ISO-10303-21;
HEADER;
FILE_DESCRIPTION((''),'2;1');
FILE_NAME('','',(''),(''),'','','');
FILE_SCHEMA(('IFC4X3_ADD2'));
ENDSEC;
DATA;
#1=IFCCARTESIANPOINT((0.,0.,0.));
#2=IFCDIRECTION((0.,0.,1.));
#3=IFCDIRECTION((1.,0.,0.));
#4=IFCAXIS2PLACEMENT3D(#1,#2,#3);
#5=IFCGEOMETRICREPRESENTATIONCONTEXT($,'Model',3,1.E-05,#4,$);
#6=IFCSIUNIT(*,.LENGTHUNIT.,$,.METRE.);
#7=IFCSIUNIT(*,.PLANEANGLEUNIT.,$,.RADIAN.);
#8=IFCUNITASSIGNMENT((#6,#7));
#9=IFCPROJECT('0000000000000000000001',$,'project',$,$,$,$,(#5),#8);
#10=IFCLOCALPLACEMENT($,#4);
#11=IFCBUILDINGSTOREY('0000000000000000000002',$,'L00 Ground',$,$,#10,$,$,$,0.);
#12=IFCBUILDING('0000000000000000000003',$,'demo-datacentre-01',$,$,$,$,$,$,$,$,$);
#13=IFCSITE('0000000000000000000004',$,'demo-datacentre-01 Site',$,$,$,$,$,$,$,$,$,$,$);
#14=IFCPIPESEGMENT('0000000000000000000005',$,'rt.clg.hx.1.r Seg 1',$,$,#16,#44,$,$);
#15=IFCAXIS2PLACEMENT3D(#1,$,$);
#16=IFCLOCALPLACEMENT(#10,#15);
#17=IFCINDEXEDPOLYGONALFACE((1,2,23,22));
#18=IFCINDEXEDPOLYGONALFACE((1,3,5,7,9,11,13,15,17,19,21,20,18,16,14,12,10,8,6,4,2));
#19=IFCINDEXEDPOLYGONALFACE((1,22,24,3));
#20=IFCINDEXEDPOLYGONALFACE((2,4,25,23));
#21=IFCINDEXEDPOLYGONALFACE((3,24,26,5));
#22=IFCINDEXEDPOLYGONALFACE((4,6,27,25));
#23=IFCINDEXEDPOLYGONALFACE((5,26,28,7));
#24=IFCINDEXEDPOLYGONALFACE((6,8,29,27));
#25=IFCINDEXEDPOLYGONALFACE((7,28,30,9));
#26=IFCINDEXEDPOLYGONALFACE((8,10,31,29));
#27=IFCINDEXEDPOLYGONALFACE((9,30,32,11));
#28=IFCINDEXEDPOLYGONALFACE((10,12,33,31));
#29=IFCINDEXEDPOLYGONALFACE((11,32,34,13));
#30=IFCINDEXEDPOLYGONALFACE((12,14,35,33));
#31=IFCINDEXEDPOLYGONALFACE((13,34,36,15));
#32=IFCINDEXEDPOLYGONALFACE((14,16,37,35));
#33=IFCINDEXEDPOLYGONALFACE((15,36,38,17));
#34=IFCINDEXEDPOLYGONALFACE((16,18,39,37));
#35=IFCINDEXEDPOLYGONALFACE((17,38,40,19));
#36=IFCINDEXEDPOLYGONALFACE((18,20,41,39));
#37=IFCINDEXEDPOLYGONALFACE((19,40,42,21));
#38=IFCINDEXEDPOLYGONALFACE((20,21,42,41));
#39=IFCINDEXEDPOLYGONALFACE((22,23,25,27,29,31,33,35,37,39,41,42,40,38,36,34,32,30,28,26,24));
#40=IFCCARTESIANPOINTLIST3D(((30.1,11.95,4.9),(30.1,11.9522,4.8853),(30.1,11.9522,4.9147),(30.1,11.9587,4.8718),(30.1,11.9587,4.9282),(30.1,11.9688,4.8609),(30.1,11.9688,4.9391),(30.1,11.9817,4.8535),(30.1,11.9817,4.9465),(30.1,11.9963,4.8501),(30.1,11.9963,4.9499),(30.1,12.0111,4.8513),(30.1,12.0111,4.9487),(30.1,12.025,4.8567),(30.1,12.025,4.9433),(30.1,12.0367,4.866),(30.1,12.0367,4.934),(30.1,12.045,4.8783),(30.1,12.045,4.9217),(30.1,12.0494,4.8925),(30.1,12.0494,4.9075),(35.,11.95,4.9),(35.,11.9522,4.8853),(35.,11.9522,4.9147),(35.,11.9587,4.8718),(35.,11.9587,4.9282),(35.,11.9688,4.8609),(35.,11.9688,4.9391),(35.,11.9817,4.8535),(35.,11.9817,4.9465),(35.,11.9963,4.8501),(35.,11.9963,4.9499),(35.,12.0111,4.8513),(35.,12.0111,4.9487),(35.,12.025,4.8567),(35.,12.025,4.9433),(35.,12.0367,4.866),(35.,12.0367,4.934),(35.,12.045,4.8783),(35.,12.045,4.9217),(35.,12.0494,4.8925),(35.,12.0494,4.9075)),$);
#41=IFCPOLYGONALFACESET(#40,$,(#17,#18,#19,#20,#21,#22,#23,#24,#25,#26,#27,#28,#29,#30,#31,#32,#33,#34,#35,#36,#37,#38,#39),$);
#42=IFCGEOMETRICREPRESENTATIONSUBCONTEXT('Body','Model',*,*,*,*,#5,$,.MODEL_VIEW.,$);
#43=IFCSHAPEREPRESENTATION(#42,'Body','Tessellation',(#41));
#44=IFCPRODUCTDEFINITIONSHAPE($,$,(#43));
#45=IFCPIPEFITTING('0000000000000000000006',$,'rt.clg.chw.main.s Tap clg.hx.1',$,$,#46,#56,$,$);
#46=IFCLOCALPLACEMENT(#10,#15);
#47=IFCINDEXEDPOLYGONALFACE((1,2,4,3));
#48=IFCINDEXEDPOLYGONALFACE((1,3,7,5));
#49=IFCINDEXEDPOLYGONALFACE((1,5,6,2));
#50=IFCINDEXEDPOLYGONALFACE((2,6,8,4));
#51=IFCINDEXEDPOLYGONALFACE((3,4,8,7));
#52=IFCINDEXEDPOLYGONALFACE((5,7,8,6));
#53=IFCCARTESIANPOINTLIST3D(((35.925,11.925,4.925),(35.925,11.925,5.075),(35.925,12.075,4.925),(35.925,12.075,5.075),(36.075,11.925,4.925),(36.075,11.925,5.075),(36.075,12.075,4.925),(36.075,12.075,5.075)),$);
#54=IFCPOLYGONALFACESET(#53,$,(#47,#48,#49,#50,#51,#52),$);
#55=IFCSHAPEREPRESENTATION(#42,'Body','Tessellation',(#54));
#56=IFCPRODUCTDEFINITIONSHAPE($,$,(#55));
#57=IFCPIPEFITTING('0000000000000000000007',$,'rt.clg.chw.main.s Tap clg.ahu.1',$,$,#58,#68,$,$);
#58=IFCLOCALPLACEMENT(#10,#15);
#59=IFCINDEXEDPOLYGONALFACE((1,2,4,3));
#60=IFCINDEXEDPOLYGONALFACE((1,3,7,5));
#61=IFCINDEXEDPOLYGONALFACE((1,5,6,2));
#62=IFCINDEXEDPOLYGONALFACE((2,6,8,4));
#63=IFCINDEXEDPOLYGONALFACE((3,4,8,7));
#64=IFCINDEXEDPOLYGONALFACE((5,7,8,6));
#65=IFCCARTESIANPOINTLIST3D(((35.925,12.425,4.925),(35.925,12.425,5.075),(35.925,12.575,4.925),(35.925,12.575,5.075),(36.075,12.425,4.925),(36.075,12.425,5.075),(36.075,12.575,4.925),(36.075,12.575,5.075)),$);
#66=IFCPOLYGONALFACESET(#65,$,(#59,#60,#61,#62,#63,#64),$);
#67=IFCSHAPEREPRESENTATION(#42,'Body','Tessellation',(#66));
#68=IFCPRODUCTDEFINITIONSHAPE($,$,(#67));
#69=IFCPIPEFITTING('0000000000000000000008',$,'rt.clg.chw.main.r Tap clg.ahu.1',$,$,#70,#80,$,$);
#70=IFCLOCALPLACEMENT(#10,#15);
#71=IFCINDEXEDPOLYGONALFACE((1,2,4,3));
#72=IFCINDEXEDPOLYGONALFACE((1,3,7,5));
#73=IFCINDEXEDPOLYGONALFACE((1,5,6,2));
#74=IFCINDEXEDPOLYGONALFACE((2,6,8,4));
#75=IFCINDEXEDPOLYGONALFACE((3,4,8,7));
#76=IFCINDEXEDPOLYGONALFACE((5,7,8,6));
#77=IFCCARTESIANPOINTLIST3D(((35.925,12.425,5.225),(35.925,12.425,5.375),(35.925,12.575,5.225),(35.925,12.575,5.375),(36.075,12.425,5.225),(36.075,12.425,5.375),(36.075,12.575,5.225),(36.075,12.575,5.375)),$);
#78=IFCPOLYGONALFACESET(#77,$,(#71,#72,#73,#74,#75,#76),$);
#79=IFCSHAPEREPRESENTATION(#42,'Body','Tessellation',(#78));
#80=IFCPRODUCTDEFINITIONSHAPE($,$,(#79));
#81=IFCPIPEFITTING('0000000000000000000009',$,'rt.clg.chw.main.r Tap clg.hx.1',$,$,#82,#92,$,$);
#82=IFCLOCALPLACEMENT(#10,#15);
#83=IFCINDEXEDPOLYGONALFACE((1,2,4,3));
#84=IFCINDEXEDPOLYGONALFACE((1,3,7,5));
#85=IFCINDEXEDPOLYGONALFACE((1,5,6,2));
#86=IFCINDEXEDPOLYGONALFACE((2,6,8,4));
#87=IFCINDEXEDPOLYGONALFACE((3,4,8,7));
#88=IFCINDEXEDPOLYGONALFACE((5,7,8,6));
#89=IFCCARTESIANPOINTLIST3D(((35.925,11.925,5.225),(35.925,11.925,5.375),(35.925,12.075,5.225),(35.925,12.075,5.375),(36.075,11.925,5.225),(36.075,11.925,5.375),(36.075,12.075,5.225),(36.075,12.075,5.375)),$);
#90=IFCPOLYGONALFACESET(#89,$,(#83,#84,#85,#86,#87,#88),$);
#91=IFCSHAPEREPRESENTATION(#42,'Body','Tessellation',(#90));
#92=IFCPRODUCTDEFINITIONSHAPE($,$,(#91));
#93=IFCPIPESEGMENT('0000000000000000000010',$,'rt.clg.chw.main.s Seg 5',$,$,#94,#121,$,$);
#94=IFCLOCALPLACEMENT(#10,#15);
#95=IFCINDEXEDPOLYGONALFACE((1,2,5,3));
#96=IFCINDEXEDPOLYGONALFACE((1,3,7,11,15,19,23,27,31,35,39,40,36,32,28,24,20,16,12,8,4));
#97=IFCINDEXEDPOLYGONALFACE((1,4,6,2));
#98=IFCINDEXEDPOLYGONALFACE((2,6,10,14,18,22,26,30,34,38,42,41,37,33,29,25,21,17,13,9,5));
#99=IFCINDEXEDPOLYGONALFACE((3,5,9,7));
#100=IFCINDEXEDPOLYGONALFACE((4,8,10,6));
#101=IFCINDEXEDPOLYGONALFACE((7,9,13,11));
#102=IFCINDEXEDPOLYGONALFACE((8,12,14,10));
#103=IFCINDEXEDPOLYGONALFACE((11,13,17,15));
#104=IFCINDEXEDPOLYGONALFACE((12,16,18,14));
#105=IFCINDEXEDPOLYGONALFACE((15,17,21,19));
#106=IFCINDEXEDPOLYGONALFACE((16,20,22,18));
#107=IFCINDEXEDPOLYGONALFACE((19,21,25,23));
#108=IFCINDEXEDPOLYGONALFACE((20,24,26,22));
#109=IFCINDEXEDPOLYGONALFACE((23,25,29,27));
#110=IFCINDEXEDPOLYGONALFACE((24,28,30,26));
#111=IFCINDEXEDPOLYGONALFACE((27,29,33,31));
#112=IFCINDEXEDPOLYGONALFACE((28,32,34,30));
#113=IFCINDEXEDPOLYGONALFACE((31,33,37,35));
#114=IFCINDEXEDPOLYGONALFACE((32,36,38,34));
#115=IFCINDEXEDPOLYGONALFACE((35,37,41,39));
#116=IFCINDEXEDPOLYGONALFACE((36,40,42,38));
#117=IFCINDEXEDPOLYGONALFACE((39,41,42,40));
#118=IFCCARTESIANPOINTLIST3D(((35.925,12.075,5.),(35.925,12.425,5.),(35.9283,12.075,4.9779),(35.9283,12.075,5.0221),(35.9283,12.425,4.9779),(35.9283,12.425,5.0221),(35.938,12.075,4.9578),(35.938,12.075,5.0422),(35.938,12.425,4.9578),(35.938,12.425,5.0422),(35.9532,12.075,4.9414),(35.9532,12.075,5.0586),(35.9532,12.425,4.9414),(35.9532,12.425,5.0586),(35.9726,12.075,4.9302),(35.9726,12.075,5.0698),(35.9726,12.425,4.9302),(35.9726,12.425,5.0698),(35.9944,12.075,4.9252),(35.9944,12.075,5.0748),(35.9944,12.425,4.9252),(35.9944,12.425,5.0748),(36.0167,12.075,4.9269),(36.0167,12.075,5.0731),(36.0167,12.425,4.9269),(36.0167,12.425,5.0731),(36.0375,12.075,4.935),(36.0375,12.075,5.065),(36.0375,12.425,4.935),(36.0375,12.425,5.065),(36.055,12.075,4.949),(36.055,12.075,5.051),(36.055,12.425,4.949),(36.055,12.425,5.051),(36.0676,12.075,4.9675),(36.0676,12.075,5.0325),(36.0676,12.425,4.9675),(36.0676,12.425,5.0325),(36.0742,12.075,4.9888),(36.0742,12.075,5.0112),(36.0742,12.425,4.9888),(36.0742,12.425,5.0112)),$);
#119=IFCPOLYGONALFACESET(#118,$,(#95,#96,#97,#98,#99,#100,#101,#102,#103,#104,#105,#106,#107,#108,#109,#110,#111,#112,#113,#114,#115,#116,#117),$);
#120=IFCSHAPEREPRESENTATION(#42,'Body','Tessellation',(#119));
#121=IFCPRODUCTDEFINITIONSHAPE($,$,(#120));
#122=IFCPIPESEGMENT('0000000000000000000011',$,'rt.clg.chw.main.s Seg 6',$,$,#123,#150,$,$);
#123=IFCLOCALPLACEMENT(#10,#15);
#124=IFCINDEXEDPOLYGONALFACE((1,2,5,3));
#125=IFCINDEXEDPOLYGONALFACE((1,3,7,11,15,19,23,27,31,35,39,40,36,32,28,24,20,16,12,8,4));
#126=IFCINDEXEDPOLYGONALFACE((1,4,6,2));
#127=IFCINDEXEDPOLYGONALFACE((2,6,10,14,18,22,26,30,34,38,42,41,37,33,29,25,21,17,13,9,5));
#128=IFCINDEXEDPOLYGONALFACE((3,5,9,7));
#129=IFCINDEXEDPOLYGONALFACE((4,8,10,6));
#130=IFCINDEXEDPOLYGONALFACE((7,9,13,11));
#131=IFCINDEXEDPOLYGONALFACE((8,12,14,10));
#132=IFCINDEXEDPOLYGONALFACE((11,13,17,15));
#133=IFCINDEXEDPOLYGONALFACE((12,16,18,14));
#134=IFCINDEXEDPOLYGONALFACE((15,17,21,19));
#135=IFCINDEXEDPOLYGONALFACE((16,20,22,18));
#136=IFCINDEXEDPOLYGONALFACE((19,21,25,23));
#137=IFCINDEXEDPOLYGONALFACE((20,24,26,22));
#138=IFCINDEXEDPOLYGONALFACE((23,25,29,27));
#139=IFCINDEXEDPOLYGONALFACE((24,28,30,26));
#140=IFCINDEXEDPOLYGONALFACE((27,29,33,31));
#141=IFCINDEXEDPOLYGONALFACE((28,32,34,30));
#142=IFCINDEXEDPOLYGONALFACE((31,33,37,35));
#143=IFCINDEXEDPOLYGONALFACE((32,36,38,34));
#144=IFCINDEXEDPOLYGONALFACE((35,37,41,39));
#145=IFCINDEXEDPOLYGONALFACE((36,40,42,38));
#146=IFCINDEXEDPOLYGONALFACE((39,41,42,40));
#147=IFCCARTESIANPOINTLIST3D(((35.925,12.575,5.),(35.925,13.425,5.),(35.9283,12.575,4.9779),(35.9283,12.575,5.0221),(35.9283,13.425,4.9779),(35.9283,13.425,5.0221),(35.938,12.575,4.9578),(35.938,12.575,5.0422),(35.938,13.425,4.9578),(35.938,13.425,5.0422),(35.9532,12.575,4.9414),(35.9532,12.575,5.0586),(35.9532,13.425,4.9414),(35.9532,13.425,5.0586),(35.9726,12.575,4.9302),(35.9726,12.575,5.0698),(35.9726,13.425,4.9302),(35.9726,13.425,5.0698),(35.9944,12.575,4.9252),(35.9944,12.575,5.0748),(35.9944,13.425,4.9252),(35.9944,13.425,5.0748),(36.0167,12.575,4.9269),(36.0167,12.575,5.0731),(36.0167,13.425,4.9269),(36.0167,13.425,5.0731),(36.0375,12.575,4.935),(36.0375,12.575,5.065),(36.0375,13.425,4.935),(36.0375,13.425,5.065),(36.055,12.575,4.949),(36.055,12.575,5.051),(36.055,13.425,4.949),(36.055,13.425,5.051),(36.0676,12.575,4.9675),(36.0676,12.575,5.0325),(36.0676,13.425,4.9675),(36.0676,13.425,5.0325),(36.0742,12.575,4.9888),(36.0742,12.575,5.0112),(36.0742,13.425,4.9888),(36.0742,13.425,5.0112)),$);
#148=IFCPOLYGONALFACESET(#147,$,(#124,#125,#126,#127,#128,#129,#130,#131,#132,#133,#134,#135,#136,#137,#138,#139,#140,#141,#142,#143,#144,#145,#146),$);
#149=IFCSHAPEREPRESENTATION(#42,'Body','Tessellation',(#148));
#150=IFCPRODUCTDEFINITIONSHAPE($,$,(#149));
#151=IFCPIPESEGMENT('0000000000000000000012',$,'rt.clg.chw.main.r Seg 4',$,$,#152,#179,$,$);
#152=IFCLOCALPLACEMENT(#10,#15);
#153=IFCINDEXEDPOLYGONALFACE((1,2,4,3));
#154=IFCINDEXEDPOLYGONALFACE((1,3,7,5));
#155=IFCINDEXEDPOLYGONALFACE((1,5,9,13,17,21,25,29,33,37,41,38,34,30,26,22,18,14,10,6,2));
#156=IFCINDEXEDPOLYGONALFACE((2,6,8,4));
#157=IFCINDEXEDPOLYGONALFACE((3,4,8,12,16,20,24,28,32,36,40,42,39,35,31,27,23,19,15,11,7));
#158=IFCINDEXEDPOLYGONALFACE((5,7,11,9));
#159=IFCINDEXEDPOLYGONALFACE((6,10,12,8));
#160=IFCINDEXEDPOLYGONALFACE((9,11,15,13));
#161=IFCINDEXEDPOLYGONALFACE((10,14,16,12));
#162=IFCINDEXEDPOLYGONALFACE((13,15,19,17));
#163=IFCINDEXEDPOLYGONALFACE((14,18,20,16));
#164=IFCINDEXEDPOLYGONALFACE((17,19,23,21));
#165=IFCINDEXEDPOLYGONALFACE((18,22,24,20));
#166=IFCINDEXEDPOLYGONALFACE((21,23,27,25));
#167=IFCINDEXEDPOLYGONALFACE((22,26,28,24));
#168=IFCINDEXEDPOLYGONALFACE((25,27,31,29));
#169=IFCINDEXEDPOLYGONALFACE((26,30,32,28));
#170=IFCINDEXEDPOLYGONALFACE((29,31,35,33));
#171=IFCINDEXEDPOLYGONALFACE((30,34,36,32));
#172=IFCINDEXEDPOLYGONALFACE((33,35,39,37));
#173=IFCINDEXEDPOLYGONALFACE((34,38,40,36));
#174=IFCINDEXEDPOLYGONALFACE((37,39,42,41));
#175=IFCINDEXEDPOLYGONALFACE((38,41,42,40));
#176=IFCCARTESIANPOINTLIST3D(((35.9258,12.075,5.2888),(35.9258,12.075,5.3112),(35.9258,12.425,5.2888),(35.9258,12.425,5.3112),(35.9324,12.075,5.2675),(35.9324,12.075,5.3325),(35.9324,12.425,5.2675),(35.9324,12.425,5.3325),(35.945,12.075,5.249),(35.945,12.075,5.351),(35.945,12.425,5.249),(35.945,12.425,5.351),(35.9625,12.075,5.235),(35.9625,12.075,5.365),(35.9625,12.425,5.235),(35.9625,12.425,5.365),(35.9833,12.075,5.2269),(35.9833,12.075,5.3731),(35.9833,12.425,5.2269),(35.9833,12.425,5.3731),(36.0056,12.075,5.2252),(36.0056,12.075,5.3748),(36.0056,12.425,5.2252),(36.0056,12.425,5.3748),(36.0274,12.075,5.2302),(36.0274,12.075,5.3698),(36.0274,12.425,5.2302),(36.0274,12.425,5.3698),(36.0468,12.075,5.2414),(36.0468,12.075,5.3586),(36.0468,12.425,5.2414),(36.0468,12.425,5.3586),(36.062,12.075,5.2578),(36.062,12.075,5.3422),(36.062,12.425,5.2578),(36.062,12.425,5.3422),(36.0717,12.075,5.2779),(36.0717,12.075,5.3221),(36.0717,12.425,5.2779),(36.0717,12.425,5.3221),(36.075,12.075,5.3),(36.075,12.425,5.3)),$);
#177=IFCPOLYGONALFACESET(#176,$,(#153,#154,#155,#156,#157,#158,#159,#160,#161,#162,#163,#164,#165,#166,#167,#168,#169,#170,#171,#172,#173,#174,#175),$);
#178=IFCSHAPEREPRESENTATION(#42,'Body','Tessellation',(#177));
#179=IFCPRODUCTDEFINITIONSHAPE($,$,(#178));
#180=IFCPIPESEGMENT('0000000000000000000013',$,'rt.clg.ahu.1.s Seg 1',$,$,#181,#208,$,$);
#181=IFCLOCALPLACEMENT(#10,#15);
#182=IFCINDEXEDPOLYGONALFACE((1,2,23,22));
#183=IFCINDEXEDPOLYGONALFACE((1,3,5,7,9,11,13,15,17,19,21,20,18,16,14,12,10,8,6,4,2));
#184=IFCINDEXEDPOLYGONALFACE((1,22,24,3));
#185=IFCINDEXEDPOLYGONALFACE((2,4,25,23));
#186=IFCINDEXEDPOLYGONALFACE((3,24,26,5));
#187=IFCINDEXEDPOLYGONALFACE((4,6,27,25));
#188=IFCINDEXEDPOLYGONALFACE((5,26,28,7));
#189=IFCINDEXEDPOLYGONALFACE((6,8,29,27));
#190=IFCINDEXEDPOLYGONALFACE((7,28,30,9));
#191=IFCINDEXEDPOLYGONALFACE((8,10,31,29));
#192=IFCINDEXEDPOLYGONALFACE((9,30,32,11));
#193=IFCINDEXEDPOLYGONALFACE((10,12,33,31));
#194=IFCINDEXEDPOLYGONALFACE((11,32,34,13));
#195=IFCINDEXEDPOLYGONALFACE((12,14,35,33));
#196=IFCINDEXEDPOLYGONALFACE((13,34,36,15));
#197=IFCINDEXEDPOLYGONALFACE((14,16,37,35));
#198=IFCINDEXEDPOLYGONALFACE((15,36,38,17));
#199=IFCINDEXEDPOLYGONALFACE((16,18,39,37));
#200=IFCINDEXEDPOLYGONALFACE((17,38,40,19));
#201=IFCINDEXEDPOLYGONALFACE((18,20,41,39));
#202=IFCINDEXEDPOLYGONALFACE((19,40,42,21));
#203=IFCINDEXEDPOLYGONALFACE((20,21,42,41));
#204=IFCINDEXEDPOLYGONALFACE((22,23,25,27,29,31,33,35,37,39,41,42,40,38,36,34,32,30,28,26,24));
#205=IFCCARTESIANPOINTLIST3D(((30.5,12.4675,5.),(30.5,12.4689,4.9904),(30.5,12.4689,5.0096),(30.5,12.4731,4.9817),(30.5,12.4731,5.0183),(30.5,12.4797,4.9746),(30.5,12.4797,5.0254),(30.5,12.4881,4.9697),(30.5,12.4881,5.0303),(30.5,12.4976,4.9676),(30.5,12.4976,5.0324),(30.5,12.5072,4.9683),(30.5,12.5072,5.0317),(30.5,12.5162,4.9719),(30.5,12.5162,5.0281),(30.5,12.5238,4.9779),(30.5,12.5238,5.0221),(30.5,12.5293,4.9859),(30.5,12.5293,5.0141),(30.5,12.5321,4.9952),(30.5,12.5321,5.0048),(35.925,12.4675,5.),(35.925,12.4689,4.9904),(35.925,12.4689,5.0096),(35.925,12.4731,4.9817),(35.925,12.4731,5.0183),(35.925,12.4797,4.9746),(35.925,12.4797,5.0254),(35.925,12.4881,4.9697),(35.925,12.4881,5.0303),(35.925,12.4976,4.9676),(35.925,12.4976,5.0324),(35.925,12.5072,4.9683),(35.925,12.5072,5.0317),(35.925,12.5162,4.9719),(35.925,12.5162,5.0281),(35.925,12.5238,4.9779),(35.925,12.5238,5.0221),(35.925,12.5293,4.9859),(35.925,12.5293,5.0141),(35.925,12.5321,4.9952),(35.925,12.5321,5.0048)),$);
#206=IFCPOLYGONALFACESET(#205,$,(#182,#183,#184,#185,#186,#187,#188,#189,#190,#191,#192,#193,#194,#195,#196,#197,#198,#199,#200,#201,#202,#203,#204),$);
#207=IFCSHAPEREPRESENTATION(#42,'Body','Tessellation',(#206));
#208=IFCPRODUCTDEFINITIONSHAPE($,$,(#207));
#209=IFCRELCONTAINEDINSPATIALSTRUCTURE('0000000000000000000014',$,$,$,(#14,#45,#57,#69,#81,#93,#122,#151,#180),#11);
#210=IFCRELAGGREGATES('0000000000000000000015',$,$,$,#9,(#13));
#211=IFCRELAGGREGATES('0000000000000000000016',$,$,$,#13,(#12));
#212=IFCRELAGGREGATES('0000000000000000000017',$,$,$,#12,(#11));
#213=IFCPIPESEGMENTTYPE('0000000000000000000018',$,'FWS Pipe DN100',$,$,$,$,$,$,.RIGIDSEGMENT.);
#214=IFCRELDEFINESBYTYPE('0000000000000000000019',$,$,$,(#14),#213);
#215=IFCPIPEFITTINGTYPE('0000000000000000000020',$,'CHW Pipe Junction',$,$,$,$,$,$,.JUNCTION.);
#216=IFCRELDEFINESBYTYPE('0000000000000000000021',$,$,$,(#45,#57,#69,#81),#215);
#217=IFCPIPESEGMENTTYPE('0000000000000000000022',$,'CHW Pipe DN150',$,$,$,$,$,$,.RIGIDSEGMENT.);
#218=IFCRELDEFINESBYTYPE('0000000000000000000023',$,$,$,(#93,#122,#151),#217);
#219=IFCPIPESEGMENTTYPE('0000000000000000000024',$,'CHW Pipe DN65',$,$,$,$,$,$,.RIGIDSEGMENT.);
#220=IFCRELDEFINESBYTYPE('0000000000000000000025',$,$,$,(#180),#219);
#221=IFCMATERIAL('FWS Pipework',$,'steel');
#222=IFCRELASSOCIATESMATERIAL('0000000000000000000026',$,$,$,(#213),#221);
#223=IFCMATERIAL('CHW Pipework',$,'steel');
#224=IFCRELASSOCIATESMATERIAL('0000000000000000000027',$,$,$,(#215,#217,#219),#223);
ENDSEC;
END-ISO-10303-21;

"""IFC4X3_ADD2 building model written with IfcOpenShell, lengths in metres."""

from ifc_helpers import new_model, si_unit, frame, origin_with_axes, place, context, subcontext, project, spatial, rectangle, circle, extrude, material, type_object, element, save


model = new_model("IFC4X3_ADD2")

# Units and contexts
model_context = context("Model", 3, precision=1e-05, world=origin_with_axes())
body_context = subcontext(model_context, "Body", "Model", "MODEL_VIEW")
ifc_project = project(units=[si_unit("LENGTHUNIT", "METRE"), si_unit("PLANEANGLEUNIT", "RADIAN")], contexts=[model_context])

# Site, building, storey
site = spatial("IfcSite", under=ifc_project, Name="demo-datacentre-01 Site")
building = spatial("IfcBuilding", under=site, Name="demo-datacentre-01")
storey_placement = place(None, origin_with_axes())
storey = spatial("IfcBuildingStorey", under=building, at=storey_placement, Name="L00 Ground", Elevation=0.0)

# Shared definitions
ifc_material_1 = material(Name="FWS Pipework", Category="steel")

# Pipe segment
pipe_segment_type_1 = type_object("IfcPipeSegmentType", Name="FWS Pipe DN100", PredefinedType="RIGIDSEGMENT", material=ifc_material_1)
for number, where, z_axis, x_axis, name in (
    (1, (35.0, 12.0, 4.9), (-1.0, 0.0, 0.0), (0.0, -1.0, 0.0), "rt.clg.hx.1.r Seg 1"),
):
    element("IfcPipeSegment", number, at=place(storey_placement, frame(where, z_axis=z_axis, x_axis=x_axis)), inside=storey, type_object=pipe_segment_type_1, Name=name, context=body_context, shape_type="SweptSolid", body=[
        extrude(circle(Radius=0.05), origin_with_axes(), (0.0, 0.0, 1.0), 4.9),
    ])

# Pipe fittings
ifc_material_2 = material(Name="CHW Pipework", Category="steel")
pipe_fitting_type_1 = type_object("IfcPipeFittingType", Name="CHW Pipe Junction", PredefinedType="JUNCTION", material=ifc_material_2)
for number, where, z_axis, x_axis, name in (
    (2, (36.0, 12.0, 4.925), (0.0, 0.0, 1.0), (1.0, 0.0, 0.0), "rt.clg.chw.main.s Tap clg.hx.1"),
    (3, (36.0, 12.5, 4.925), (0.0, 0.0, 1.0), (1.0, 0.0, 0.0), "rt.clg.chw.main.s Tap clg.ahu.1"),
    (4, (36.0, 12.5, 5.225), (0.0, 0.0, 1.0), (1.0, 0.0, 0.0), "rt.clg.chw.main.r Tap clg.ahu.1"),
    (5, (36.0, 12.0, 5.225), (0.0, 0.0, 1.0), (1.0, 0.0, 0.0), "rt.clg.chw.main.r Tap clg.hx.1"),
):
    element("IfcPipeFitting", number, at=place(storey_placement, frame(where, z_axis=z_axis, x_axis=x_axis)), inside=storey, type_object=pipe_fitting_type_1, Name=name, context=body_context, shape_type="SweptSolid", body=[
        extrude(rectangle(XDim=0.15, YDim=0.15), origin_with_axes(), (0.0, 0.0, 1.0), 0.15),
    ])

# Pipe segments
pipe_segment_type_2 = type_object("IfcPipeSegmentType", Name="CHW Pipe DN150", PredefinedType="RIGIDSEGMENT", material=ifc_material_2)
pipe_segment_1_placement = place(storey_placement, frame((36.0, 12.075, 5.0), z_axis=(0.0, 1.0, 0.0), x_axis=(-1.0, 0.0, 0.0)))
element("IfcPipeSegment", 6, at=pipe_segment_1_placement, inside=storey, type_object=pipe_segment_type_2, Name="rt.clg.chw.main.s Seg 5", context=body_context, shape_type="SweptSolid", body=[
    extrude(circle(Radius=0.075), origin_with_axes(), (0.0, 0.0, 1.0), 0.35),
])
pipe_segment_2_placement = place(storey_placement, frame((36.0, 12.575, 5.0), z_axis=(0.0, 1.0, 0.0), x_axis=(-1.0, 0.0, 0.0)))
element("IfcPipeSegment", 7, at=pipe_segment_2_placement, inside=storey, type_object=pipe_segment_type_2, Name="rt.clg.chw.main.s Seg 6", context=body_context, shape_type="SweptSolid", body=[
    extrude(circle(Radius=0.075), origin_with_axes(), (0.0, 0.0, 1.0), 0.85),
])
pipe_segment_3_placement = place(storey_placement, frame((36.0, 12.425, 5.3), z_axis=(0.0, -1.0, 0.0), x_axis=(1.0, 0.0, 0.0)))
element("IfcPipeSegment", 8, at=pipe_segment_3_placement, inside=storey, type_object=pipe_segment_type_2, Name="rt.clg.chw.main.r Seg 4", context=body_context, shape_type="SweptSolid", body=[
    extrude(circle(Radius=0.075), origin_with_axes(), (0.0, 0.0, 1.0), 0.35),
])
pipe_segment_type_3 = type_object("IfcPipeSegmentType", Name="CHW Pipe DN65", PredefinedType="RIGIDSEGMENT", material=ifc_material_2)
pipe_segment_4_placement = place(storey_placement, frame((35.925, 12.5, 5.0), z_axis=(-1.0, 0.0, 0.0), x_axis=(0.0, -1.0, 0.0)))
element("IfcPipeSegment", 9, at=pipe_segment_4_placement, inside=storey, type_object=pipe_segment_type_3, Name="rt.clg.ahu.1.s Seg 1", context=body_context, shape_type="SweptSolid", body=[
    extrude(circle(Radius=0.0325), origin_with_axes(), (0.0, 0.0, 1.0), 5.425),
])

save(model, "model.ifc")
